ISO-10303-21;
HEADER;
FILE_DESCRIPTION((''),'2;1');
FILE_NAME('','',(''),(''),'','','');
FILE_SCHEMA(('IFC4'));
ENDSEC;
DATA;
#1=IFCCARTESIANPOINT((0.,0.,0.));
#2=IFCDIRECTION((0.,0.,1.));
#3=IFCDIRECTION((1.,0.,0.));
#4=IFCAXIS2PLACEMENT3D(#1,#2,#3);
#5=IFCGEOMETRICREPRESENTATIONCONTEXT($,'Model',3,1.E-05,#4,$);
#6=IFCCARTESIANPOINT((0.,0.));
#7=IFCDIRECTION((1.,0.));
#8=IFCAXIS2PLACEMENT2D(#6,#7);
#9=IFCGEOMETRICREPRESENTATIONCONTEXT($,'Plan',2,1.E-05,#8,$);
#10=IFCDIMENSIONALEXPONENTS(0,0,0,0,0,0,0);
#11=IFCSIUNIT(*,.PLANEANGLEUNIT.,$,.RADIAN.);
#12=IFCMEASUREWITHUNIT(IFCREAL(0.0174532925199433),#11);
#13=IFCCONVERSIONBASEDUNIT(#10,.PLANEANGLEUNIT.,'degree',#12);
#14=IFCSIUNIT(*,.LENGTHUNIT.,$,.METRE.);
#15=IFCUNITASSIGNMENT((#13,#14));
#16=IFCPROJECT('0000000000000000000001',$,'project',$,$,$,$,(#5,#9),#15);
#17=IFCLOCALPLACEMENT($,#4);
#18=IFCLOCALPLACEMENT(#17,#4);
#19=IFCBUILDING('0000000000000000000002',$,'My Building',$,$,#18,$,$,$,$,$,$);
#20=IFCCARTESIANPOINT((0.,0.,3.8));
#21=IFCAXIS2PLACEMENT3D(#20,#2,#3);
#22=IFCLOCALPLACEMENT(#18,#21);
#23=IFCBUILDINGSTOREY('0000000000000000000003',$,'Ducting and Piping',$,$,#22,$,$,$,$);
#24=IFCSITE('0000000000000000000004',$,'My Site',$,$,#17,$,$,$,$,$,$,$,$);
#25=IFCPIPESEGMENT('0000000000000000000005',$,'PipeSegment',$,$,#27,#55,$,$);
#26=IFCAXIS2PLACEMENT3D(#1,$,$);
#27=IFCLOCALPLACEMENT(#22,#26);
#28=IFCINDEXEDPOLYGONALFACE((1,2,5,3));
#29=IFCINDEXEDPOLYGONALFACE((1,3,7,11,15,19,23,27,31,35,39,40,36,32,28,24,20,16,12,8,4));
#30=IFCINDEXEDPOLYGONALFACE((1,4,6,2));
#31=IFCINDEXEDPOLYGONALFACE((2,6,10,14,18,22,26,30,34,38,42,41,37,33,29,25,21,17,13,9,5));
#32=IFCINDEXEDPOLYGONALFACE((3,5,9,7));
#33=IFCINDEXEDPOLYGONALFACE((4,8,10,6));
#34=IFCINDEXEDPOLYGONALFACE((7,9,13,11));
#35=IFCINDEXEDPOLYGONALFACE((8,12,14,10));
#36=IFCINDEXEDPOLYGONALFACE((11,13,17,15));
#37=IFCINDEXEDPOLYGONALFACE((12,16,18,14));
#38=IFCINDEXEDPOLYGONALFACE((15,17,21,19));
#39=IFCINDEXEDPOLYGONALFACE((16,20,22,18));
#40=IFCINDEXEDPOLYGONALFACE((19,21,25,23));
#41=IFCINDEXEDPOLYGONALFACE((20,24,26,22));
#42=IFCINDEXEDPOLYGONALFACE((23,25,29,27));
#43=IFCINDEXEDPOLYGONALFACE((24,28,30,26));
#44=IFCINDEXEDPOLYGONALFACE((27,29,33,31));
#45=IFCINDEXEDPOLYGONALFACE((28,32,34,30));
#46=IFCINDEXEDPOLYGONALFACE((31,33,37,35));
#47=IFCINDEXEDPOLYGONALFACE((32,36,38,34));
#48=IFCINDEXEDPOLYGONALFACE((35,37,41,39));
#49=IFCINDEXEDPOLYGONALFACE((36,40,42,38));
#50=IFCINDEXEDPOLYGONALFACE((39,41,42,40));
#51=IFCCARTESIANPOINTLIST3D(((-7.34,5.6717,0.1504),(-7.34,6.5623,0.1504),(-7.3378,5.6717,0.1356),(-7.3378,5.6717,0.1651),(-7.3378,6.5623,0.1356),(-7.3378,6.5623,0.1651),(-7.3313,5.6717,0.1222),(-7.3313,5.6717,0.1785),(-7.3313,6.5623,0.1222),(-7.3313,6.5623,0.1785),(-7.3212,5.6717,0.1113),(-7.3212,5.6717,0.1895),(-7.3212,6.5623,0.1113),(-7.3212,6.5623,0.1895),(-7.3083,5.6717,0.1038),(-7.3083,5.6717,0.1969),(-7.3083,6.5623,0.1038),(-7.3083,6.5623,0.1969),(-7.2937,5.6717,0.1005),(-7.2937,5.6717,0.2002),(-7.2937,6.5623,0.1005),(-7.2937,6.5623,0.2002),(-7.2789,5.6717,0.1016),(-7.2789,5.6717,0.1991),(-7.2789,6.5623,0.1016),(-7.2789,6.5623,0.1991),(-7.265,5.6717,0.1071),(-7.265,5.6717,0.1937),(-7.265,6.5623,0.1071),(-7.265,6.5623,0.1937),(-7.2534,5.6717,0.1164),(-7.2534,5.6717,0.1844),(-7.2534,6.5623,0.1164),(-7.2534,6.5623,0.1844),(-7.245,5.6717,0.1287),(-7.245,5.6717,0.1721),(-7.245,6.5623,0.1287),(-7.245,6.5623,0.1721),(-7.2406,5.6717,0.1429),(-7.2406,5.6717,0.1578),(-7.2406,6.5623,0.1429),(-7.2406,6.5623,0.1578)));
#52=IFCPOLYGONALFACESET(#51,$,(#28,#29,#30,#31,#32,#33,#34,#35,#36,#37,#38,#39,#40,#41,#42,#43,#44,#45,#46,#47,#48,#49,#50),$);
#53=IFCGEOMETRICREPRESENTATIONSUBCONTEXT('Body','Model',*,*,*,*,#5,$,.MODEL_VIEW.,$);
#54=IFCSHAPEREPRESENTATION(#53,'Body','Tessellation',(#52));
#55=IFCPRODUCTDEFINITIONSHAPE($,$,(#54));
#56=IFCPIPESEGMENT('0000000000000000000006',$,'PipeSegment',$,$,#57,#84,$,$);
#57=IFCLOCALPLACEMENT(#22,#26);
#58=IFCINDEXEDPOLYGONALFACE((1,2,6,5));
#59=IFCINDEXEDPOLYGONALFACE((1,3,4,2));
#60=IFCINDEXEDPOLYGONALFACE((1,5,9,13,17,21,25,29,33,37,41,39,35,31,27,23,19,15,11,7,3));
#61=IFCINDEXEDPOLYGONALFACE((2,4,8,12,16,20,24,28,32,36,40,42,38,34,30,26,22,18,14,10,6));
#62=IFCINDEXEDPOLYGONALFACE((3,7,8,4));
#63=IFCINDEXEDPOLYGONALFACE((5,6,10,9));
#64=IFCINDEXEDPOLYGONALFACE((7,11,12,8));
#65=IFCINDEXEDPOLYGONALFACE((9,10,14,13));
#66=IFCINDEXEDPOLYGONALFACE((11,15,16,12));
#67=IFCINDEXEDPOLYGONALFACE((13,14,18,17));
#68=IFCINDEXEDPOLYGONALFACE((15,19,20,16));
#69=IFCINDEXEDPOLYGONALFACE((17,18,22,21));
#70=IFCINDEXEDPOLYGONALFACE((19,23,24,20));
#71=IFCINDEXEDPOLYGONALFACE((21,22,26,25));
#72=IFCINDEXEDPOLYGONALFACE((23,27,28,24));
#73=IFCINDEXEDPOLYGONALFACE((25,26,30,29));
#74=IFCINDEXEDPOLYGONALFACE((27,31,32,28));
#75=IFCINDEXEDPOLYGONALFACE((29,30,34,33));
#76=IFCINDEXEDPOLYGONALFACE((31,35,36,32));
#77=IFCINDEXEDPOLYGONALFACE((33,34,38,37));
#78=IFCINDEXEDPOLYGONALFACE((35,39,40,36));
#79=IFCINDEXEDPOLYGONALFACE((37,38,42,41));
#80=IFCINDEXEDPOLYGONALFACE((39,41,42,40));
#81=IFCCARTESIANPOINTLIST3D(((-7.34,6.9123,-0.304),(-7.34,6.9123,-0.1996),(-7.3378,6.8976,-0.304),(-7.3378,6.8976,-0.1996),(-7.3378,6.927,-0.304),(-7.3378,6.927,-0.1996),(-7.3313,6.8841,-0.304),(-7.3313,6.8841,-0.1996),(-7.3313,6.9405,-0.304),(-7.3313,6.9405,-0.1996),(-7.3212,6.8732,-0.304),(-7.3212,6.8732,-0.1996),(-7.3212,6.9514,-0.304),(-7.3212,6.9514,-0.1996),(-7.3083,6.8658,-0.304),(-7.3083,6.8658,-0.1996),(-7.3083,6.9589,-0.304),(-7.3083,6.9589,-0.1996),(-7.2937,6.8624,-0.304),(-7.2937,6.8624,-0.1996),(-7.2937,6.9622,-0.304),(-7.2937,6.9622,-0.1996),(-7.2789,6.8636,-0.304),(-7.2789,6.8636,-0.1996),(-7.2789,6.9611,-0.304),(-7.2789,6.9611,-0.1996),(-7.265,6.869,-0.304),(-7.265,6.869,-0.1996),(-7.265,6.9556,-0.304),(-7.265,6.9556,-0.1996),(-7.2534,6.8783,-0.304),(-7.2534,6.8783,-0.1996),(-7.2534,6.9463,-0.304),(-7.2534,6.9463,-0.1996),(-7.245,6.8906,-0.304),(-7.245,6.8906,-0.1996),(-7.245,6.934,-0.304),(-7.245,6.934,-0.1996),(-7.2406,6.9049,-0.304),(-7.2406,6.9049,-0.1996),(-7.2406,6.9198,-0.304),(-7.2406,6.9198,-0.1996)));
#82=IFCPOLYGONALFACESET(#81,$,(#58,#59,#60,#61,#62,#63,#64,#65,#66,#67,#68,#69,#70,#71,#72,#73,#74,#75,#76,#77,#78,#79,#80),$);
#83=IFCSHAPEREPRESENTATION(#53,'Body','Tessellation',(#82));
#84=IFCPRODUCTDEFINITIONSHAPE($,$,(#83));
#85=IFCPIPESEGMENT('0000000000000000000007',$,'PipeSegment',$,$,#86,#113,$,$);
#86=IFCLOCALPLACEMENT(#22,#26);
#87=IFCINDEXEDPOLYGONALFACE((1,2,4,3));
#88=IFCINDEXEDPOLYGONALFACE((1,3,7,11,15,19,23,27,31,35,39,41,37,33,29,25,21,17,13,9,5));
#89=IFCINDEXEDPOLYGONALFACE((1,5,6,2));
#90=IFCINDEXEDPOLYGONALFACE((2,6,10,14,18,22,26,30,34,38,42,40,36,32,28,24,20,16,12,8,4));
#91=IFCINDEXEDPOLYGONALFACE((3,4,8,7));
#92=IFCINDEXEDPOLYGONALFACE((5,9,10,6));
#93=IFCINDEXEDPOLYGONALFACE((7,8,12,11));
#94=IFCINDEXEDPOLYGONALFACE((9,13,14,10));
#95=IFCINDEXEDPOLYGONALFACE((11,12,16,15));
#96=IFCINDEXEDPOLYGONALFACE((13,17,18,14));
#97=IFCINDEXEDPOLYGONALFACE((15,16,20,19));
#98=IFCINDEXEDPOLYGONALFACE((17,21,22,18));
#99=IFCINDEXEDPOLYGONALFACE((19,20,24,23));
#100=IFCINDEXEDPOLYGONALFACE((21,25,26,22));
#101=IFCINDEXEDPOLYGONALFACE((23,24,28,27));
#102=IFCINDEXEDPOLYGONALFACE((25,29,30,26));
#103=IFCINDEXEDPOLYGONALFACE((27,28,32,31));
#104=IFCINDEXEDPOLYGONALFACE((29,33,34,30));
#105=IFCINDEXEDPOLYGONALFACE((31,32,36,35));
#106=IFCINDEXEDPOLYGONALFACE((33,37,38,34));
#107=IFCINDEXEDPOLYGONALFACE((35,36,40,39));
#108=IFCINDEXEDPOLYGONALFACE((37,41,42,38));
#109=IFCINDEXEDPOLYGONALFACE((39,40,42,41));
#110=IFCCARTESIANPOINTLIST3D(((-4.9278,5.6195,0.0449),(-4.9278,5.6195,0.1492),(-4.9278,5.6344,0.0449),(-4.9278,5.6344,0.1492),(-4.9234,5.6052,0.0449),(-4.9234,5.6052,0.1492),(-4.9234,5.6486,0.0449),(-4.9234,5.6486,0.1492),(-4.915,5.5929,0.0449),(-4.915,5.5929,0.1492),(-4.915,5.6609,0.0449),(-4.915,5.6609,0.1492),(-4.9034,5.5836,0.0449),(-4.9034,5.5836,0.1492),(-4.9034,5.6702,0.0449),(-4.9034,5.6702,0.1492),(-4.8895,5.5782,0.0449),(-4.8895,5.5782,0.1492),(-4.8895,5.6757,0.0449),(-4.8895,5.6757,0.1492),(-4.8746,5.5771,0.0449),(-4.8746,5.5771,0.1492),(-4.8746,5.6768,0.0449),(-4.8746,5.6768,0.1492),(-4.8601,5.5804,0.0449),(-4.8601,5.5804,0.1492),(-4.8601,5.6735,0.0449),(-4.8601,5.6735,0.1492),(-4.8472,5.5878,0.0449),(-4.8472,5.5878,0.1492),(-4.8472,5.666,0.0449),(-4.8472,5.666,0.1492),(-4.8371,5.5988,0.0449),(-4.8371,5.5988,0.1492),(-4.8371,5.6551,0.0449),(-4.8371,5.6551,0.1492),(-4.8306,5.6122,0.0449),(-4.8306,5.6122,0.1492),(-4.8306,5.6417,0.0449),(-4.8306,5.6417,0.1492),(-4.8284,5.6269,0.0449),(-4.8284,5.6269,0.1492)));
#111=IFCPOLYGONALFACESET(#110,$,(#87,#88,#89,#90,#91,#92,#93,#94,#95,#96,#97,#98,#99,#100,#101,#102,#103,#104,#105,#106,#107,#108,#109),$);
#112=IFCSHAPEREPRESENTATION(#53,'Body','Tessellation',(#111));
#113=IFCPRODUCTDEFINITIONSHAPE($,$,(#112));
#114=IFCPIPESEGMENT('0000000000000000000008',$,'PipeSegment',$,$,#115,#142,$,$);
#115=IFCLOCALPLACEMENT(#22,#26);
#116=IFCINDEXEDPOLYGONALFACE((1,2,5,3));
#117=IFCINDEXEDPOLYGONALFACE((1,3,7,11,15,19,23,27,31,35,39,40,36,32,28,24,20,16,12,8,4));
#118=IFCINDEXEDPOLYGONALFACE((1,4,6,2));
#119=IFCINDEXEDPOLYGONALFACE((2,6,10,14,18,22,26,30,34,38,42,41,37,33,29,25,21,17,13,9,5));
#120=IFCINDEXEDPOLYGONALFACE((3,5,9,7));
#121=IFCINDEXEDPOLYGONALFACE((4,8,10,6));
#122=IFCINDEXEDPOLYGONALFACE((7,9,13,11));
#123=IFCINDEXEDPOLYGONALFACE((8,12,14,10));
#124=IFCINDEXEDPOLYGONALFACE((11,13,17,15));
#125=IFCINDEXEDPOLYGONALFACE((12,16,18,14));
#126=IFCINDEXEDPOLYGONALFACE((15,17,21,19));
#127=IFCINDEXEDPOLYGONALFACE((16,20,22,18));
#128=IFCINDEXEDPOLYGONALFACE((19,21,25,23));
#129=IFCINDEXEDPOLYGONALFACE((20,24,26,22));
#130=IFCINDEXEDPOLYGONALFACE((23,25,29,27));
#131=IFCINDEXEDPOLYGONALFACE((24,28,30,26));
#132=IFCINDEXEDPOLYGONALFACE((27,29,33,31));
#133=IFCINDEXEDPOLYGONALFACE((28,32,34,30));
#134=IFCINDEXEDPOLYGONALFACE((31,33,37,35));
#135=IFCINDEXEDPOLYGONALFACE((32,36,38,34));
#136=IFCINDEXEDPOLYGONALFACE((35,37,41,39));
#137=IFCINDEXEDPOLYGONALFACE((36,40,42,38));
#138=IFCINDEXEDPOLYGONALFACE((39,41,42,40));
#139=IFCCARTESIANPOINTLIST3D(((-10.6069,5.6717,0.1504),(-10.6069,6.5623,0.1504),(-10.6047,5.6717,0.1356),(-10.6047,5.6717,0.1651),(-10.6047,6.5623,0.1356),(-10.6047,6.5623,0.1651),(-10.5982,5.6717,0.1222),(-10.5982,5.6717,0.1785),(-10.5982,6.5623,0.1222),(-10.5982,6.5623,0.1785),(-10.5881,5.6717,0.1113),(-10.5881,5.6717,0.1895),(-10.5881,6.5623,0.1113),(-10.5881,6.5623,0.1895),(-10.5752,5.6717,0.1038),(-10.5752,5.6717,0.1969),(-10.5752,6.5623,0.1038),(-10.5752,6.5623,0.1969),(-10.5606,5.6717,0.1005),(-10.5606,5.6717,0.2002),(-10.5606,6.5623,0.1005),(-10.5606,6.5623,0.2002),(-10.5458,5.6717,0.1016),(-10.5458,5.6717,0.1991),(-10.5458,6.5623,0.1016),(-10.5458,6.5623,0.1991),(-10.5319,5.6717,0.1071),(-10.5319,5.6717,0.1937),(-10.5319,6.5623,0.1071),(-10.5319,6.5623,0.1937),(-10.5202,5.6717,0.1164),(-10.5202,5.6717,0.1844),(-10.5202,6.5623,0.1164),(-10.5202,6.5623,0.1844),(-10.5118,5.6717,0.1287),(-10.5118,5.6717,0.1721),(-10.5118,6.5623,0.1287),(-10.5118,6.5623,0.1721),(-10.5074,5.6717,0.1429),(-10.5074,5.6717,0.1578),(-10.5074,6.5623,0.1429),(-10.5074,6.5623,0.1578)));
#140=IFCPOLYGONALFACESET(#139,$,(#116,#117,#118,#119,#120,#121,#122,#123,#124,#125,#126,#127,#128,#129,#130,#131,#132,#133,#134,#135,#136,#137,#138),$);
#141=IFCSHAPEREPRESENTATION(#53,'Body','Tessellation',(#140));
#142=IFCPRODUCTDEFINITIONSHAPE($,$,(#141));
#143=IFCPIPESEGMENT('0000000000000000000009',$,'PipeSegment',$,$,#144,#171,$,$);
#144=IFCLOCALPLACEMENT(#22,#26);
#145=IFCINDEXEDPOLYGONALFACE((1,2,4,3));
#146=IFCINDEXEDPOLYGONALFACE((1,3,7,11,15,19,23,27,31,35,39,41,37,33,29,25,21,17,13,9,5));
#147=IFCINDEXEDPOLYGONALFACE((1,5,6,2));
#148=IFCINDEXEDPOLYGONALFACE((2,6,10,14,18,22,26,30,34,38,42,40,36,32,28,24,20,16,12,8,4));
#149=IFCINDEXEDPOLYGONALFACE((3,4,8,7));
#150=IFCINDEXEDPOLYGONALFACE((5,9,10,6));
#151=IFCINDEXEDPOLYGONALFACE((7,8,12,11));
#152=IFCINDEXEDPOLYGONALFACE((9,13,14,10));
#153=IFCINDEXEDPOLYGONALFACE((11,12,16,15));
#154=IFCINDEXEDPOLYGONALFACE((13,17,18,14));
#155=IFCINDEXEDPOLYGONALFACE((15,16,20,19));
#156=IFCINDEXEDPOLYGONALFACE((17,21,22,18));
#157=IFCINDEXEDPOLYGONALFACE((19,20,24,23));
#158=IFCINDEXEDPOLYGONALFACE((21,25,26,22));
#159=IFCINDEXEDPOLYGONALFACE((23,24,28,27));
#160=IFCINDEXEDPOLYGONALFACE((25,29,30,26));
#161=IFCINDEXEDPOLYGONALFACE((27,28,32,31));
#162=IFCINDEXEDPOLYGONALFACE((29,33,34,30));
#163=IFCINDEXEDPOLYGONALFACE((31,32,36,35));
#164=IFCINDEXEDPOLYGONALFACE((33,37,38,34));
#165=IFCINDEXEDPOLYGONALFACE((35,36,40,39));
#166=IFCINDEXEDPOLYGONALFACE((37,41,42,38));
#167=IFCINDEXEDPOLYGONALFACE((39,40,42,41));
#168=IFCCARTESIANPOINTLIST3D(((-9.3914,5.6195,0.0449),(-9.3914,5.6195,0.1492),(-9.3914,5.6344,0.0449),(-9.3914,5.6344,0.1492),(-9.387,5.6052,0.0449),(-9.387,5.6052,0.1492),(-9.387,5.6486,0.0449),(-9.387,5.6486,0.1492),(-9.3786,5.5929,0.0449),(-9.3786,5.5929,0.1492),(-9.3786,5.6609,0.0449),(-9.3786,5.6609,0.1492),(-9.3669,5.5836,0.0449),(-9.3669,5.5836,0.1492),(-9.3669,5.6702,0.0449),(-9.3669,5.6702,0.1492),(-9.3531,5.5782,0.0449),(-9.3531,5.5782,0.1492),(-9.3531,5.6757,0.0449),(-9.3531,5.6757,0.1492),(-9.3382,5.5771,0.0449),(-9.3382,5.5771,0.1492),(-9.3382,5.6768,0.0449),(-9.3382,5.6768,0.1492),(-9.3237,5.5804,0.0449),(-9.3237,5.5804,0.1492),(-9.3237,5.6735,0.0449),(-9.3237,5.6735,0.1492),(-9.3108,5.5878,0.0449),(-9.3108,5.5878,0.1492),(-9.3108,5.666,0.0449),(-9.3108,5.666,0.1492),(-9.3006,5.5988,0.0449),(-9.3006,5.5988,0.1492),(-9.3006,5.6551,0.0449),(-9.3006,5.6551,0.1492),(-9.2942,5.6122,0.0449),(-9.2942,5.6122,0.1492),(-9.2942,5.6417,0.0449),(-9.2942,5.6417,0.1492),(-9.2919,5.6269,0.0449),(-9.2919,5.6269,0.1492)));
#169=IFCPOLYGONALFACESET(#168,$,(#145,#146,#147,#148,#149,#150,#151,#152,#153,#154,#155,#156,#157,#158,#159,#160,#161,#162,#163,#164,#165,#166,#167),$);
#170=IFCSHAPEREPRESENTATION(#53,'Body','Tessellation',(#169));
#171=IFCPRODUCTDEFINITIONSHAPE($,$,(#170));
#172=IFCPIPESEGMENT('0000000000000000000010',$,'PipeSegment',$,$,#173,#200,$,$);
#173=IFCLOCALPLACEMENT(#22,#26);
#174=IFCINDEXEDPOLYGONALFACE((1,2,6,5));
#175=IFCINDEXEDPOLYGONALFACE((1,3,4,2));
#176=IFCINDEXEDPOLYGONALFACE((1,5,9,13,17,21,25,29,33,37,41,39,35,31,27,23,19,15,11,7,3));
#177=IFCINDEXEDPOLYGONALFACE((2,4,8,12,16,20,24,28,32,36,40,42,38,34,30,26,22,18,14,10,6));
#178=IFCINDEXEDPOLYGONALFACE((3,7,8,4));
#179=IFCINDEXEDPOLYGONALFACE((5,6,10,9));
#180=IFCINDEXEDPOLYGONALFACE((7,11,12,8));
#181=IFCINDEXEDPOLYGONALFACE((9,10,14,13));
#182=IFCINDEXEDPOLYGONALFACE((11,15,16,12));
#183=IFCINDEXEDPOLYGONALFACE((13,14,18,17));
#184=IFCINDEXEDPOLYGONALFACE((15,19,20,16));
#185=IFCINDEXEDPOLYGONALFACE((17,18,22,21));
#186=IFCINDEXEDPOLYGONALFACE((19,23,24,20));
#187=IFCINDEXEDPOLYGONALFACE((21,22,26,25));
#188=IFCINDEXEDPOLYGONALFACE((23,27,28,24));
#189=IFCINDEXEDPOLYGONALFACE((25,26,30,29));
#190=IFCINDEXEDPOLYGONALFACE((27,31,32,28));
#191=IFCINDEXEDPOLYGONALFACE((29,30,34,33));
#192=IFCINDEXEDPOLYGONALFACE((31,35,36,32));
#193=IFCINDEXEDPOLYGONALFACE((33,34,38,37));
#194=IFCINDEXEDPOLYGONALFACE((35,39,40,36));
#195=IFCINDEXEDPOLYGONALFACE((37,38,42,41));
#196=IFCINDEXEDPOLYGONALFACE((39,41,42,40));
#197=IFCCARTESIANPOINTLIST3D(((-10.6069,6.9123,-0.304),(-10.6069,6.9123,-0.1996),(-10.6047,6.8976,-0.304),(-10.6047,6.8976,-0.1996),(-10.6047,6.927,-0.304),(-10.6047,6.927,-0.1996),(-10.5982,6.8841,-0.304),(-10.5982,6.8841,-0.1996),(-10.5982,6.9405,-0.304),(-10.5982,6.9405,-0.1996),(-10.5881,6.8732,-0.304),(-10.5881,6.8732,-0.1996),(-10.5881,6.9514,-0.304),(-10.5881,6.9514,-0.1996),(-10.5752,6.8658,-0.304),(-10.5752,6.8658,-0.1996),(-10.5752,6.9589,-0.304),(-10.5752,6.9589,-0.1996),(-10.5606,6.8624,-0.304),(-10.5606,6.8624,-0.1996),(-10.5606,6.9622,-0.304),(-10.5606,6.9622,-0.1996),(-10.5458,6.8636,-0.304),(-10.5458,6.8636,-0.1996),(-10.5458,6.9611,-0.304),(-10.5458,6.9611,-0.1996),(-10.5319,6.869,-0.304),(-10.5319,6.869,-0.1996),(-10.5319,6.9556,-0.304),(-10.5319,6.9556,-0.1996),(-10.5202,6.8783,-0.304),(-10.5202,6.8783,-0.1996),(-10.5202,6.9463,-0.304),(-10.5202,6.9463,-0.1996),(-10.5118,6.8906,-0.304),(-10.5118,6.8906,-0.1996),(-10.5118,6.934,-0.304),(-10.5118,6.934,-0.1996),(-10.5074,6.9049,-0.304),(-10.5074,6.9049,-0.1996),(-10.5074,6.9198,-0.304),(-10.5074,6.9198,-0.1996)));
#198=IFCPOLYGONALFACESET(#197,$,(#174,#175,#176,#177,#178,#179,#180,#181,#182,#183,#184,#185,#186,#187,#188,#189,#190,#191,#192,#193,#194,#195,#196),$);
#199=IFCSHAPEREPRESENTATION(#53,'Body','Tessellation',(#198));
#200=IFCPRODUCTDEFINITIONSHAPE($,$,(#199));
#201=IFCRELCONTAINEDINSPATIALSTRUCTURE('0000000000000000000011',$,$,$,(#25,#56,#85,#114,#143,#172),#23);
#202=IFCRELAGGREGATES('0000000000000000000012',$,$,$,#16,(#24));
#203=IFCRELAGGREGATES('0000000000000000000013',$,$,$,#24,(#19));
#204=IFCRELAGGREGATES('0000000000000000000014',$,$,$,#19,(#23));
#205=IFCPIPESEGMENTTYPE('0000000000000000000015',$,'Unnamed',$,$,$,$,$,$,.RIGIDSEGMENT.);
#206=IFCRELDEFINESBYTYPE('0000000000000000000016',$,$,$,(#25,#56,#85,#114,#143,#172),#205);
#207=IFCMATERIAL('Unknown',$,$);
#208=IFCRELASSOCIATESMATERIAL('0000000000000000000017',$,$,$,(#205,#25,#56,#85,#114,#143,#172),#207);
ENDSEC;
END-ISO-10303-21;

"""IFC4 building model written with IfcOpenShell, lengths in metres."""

from ifc_helpers import new_model, entity, si_unit, converted_unit, frame, origin_with_axes, origin_2d_with_axis, place, context, subcontext, project, spatial, circle, extrude, material, material_profile, profile_set, profile_usage, type_object, element, save


model = new_model("IFC4")

# Units and contexts
model_context = context("Model", 3, precision=1e-05, world=origin_with_axes())
plan_context = context("Plan", 2, precision=1e-05, world=origin_2d_with_axis())
body_context = subcontext(model_context, "Body", "Model", "MODEL_VIEW")
ifc_project = project(units=[converted_unit("PLANEANGLEUNIT", "degree", entity("IfcReal", 0.0174532925199433), si_unit("PLANEANGLEUNIT", "RADIAN"), dimensions=[0, 0, 0, 0, 0, 0, 0]), si_unit("LENGTHUNIT", "METRE")], contexts=[model_context, plan_context])

# Site, building, storey
site_placement = place(None, origin_with_axes())
site = spatial("IfcSite", under=ifc_project, at=site_placement, Name="My Site")
building_placement = place(site_placement, origin_with_axes())
building = spatial("IfcBuilding", under=site, at=building_placement, Name="My Building")
storey_placement = place(building_placement, frame((0.0, 0.0, 3.8), z_axis=(0.0, 0.0, 1.0), x_axis=(1.0, 0.0, 0.0)))
storey = spatial("IfcBuildingStorey", under=building, at=storey_placement, Name="Ducting and Piping")

# Pipe segments
ifc_material = material(Name="Unknown")
ifc_material_profile_1 = material_profile(ifc_material, circle(Radius=0.05))
ifc_profile_set_1 = profile_set([ifc_material_profile_1])
ifc_profile_usage_1 = profile_usage(ifc_profile_set_1, cardinal=5)
pipe_segment_type = type_object("IfcPipeSegmentType", Name="Unnamed", PredefinedType="RIGIDSEGMENT", material=ifc_profile_set_1)
pipe_segment_1_placement = place(storey_placement, frame((-7.29, 5.6717, 0.1504), z_axis=(0.0, 1.0, 0.0), x_axis=(-1.0, 0.0, 0.0)))
element("IfcPipeSegment", 1, at=pipe_segment_1_placement, inside=storey, type_object=pipe_segment_type, material=ifc_profile_usage_1, Name="PipeSegment", context=body_context, shape_type="SweptSolid", body=[
    extrude(circle(Radius=0.05), origin_with_axes(), (0.0, 0.0, 1.0), 0.8907),
])
ifc_profile_usage_2 = profile_usage(ifc_profile_set_1, cardinal=5)
pipe_segment_2_placement = place(storey_placement, frame((-7.29, 6.9123, -0.304), z_axis=(0.0, 0.0, 1.0), x_axis=(-1.0, 0.0, 0.0)))
element("IfcPipeSegment", 2, at=pipe_segment_2_placement, inside=storey, type_object=pipe_segment_type, material=ifc_profile_usage_2, Name="PipeSegment", context=body_context, shape_type="SweptSolid", body=[
    extrude(circle(Radius=0.05), origin_with_axes(), (0.0, 0.0, 1.0), 0.1043),
])
ifc_profile_usage_3 = profile_usage(ifc_profile_set_1, cardinal=5)
pipe_segment_3_placement = place(storey_placement, frame((-4.8784, 5.6269, 0.0449), z_axis=(0.0, 0.0, 1.0), x_axis=(1.0, 0.00006, 0.0)))
element("IfcPipeSegment", 3, at=pipe_segment_3_placement, inside=storey, type_object=pipe_segment_type, material=ifc_profile_usage_3, Name="PipeSegment", context=body_context, shape_type="SweptSolid", body=[
    extrude(circle(Radius=0.05), origin_with_axes(), (0.0, 0.0, 1.0), 0.1043),
])
ifc_profile_usage_4 = profile_usage(ifc_profile_set_1, cardinal=5)
pipe_segment_4_placement = place(storey_placement, frame((-10.5569, 5.6717, 0.1504), z_axis=(0.0, 1.0, 0.0), x_axis=(-1.0, 0.0, 0.0)))
element("IfcPipeSegment", 4, at=pipe_segment_4_placement, inside=storey, type_object=pipe_segment_type, material=ifc_profile_usage_4, Name="PipeSegment", context=body_context, shape_type="SweptSolid", body=[
    extrude(circle(Radius=0.05), origin_with_axes(), (0.0, 0.0, 1.0), 0.8907),
])
ifc_profile_usage_5 = profile_usage(ifc_profile_set_1, cardinal=5)
pipe_segment_5_placement = place(storey_placement, frame((-9.3419, 5.6269, 0.0449), z_axis=(0.0, 0.0, 1.0), x_axis=(1.0, 0.00006, 0.0)))
element("IfcPipeSegment", 5, at=pipe_segment_5_placement, inside=storey, type_object=pipe_segment_type, material=ifc_profile_usage_5, Name="PipeSegment", context=body_context, shape_type="SweptSolid", body=[
    extrude(circle(Radius=0.05), origin_with_axes(), (0.0, 0.0, 1.0), 0.1043),
])
ifc_profile_usage_6 = profile_usage(ifc_profile_set_1, cardinal=5)
pipe_segment_6_placement = place(storey_placement, frame((-10.5569, 6.9123, -0.304), z_axis=(0.0, 0.0, 1.0), x_axis=(-1.0, 0.0, 0.0)))
element("IfcPipeSegment", 6, at=pipe_segment_6_placement, inside=storey, type_object=pipe_segment_type, material=ifc_profile_usage_6, Name="PipeSegment", context=body_context, shape_type="SweptSolid", body=[
    extrude(circle(Radius=0.05), origin_with_axes(), (0.0, 0.0, 1.0), 0.1043),
])

save(model, "model.ifc")
